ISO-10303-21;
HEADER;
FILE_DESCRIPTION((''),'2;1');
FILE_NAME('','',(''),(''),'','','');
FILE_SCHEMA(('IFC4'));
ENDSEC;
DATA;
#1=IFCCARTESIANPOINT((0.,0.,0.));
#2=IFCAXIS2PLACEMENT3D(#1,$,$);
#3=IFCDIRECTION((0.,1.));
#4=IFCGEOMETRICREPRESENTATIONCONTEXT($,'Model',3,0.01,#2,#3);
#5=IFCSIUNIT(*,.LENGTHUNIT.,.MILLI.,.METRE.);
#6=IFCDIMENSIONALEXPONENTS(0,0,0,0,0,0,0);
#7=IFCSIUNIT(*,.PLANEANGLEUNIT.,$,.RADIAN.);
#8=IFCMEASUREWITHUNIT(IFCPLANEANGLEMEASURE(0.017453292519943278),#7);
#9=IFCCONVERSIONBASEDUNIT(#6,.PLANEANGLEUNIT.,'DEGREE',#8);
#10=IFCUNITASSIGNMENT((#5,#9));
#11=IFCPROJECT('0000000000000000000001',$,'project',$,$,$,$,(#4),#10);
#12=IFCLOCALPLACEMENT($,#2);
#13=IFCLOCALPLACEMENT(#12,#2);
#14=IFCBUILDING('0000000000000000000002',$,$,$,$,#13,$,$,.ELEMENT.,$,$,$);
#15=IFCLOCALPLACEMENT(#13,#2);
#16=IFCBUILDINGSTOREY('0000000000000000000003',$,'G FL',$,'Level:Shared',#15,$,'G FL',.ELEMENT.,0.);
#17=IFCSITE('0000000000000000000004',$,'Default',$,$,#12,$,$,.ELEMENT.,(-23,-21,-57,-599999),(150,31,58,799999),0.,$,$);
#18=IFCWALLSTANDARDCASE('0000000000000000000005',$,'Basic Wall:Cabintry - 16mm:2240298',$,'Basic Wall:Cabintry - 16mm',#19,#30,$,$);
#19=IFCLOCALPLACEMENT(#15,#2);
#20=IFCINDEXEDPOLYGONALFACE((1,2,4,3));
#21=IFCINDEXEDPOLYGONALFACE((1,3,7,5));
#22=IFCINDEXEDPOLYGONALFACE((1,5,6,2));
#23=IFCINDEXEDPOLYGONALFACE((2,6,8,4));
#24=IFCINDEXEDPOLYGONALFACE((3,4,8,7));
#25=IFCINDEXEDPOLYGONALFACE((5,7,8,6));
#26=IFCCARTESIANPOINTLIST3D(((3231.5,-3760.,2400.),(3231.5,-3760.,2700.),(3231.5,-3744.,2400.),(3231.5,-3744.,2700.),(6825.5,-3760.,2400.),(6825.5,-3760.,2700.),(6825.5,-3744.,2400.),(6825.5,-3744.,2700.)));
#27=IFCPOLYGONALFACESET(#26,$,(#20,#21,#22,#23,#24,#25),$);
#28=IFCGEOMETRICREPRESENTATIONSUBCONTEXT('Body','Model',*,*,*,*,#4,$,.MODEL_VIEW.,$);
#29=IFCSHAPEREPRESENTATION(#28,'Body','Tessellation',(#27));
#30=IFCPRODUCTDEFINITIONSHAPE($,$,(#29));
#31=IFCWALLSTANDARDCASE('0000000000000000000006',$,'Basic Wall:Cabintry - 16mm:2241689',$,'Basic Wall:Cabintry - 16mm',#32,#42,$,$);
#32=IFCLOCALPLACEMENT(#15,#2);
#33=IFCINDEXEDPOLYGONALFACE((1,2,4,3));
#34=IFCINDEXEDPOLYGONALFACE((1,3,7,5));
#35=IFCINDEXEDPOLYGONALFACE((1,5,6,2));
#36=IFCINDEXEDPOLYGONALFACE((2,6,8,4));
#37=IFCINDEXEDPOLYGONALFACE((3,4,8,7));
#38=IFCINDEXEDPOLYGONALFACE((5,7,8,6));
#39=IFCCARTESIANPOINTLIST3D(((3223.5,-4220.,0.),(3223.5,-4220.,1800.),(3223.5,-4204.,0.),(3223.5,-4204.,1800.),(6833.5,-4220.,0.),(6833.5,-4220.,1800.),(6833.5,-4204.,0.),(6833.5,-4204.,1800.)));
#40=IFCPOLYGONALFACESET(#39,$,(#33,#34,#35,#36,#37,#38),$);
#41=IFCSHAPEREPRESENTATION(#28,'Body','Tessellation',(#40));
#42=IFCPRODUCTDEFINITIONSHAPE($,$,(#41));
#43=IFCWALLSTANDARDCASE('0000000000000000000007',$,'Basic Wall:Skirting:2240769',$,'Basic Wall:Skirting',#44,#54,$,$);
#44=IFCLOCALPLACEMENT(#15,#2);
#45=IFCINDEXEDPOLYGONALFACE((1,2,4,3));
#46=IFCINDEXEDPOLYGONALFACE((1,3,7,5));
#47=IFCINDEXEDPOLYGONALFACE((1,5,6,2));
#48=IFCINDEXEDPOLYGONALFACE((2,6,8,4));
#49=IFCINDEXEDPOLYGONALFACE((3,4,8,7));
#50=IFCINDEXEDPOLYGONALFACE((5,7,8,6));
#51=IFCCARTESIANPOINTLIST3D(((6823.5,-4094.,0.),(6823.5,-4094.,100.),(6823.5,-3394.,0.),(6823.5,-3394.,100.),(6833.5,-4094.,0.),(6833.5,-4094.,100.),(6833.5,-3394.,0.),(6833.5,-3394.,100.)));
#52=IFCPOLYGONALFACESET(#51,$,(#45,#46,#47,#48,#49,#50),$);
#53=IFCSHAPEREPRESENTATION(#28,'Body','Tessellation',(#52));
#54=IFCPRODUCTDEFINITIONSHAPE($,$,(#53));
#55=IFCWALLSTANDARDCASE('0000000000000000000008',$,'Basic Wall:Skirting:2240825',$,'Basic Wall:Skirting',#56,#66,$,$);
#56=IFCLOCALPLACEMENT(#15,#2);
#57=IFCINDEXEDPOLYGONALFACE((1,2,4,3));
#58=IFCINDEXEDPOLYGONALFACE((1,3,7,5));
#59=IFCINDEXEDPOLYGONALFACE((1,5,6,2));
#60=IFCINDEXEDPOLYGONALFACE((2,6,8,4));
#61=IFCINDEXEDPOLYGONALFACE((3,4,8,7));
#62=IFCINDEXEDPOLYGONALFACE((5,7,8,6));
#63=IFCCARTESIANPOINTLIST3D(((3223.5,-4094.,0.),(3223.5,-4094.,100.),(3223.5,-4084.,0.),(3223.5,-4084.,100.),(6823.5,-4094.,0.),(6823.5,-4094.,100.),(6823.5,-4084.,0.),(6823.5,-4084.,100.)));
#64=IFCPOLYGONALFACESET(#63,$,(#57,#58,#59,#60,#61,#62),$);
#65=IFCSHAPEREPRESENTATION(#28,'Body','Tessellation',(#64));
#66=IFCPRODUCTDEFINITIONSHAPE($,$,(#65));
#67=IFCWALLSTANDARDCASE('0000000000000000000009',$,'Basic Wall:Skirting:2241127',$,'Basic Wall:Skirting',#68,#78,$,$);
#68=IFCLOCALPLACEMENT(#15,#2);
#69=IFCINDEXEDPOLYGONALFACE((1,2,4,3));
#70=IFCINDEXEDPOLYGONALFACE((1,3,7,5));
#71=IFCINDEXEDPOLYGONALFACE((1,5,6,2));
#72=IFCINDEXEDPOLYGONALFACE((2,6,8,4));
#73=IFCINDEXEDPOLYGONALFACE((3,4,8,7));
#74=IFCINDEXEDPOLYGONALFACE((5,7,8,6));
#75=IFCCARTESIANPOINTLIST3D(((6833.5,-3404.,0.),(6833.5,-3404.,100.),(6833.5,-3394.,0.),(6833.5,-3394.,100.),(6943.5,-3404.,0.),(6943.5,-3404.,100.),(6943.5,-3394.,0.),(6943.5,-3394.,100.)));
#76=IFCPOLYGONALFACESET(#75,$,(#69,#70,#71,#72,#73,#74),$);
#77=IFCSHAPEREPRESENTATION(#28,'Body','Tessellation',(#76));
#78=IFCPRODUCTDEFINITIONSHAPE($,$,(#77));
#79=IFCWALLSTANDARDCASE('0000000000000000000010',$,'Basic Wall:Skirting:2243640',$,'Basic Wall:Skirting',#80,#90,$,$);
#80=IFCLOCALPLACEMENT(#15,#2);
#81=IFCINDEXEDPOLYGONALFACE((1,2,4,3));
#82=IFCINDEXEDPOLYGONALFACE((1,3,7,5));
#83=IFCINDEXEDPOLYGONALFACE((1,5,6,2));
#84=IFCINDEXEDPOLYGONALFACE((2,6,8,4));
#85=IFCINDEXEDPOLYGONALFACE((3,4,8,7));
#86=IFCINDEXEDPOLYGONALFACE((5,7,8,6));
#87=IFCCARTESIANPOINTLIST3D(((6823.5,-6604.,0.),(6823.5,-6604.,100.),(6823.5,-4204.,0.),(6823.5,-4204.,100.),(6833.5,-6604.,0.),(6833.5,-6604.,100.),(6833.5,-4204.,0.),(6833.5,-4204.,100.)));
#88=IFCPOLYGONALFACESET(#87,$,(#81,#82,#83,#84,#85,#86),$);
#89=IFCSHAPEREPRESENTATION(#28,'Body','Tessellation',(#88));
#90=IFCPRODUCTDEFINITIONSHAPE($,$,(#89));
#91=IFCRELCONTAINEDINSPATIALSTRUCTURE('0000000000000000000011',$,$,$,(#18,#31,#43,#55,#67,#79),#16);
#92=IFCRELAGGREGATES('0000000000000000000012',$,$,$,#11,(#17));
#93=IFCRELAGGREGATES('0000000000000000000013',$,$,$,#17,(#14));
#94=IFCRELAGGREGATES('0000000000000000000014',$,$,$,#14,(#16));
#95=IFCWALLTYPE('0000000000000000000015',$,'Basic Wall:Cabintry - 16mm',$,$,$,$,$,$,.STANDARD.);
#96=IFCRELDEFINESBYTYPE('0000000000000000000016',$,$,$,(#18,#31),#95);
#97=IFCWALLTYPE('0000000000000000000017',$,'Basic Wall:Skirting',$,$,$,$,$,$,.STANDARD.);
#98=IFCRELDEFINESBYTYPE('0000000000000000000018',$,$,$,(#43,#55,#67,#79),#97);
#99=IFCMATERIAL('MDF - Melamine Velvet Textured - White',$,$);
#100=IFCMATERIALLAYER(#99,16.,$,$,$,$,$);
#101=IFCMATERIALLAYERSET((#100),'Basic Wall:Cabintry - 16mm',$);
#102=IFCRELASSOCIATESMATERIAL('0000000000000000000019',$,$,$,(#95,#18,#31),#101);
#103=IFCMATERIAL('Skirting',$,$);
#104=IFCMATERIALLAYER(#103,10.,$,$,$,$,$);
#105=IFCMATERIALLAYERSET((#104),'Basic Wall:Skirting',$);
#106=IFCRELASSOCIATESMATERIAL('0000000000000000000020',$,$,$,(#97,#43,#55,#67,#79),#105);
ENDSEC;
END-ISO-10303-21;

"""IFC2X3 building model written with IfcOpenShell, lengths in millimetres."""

from ifc_helpers import new_model, entity, si_unit, converted_unit, direction, frame, frame_2d, origin, place, context, subcontext, project, spatial, rectangle, extrude, material, layer, layer_set, layer_usage, type_object, element, save


model = new_model("IFC2X3")

# Units and contexts
model_context = context("Model", 3, precision=0.01, world=origin(), true_north=direction((0.0, 1.0)))
body_context = subcontext(model_context, "Body", "Model", "MODEL_VIEW")
ifc_project = project(units=[si_unit("LENGTHUNIT", "METRE", prefix="MILLI"), converted_unit("PLANEANGLEUNIT", "DEGREE", entity("IfcPlaneAngleMeasure", 0.017453292519943278), si_unit("PLANEANGLEUNIT", "RADIAN"), dimensions=[0, 0, 0, 0, 0, 0, 0])], contexts=[model_context])

# Site, building, storey
site_placement = place(None, origin())
site = spatial("IfcSite", under=ifc_project, at=site_placement, Name="Default", CompositionType="ELEMENT", RefLatitude=(-23, -21, -57, -599999), RefLongitude=(150, 31, 58, 799999), RefElevation=0.0)
building_placement = place(site_placement, origin())
building = spatial("IfcBuilding", under=site, at=building_placement, CompositionType="ELEMENT")
storey_placement = place(building_placement, origin())
storey = spatial("IfcBuildingStorey", under=building, at=storey_placement, Name="G FL", ObjectType="Level:Shared", LongName="G FL", CompositionType="ELEMENT", Elevation=0.0)

# Walls
ifc_material_1 = material(Name="MDF - Melamine Velvet Textured - White")
ifc_layer_1 = layer(ifc_material_1, 16.0)
ifc_layer_set_1 = layer_set([ifc_layer_1], Name="Basic Wall:Cabintry - 16mm")
wall_type_1 = type_object("IfcWallType", Name="Basic Wall:Cabintry - 16mm", PredefinedType="STANDARD", material=ifc_layer_set_1)
ifc_layer_usage_1 = layer_usage(ifc_layer_set_1, "AXIS2", "NEGATIVE", 8.0)
wall_1_placement = place(storey_placement, frame((6825.5, -3752.0, 2400.0), z_axis=(0.0, 0.0, 1.0), x_axis=(-1.0, 0.0, 0.0)))
element("IfcWallStandardCase", 1, at=wall_1_placement, inside=storey, type_object=wall_type_1, material=ifc_layer_usage_1, Name="Basic Wall:Cabintry - 16mm:2240298", ObjectType="Basic Wall:Cabintry - 16mm", context=body_context, shape_type="SweptSolid", body=[
    extrude(rectangle(XDim=3594.0, YDim=16.0, at=frame_2d((1797.0, 0.0), x_axis=(-1.0, 0.0))), origin(), (0.0, 0.0, 1.0), 300.0),
])
ifc_layer_usage_2 = layer_usage(ifc_layer_set_1, "AXIS2", "NEGATIVE", 8.0)
wall_2_placement = place(storey_placement, frame((6833.5, -4212.0, 0.0), z_axis=(0.0, 0.0, 1.0), x_axis=(-1.0, 0.0, 0.0)))
element("IfcWallStandardCase", 2, at=wall_2_placement, inside=storey, type_object=wall_type_1, material=ifc_layer_usage_2, Name="Basic Wall:Cabintry - 16mm:2241689", ObjectType="Basic Wall:Cabintry - 16mm", context=body_context, shape_type="SweptSolid", body=[
    extrude(rectangle(XDim=3610.0, YDim=16.0, at=frame_2d((1805.0, 0.0), x_axis=(-1.0, 0.0))), origin(), (0.0, 0.0, 1.0), 1800.0),
])

# Shared definitions
ifc_material_2 = material(Name="Skirting")
ifc_layer_2 = layer(ifc_material_2, 10.0)
ifc_layer_set_2 = layer_set([ifc_layer_2], Name="Basic Wall:Skirting")
wall_type_2 = type_object("IfcWallType", Name="Basic Wall:Skirting", PredefinedType="STANDARD", material=ifc_layer_set_2)

# Walls
ifc_layer_usage_3 = layer_usage(ifc_layer_set_2, "AXIS2", "NEGATIVE", 5.0)
wall_3_placement = place(storey_placement, frame((6828.5, -3394.0, 0.0), z_axis=(0.0, 0.0, 1.0), x_axis=(0.0, -1.0, 0.0)))
element("IfcWallStandardCase", 3, at=wall_3_placement, inside=storey, type_object=wall_type_2, material=ifc_layer_usage_3, Name="Basic Wall:Skirting:2240769", ObjectType="Basic Wall:Skirting", context=body_context, shape_type="SweptSolid", body=[
    extrude(rectangle(XDim=700.0, YDim=10.0, at=frame_2d((350.0, 0.0), x_axis=(-1.0, 0.0))), origin(), (0.0, 0.0, 1.0), 100.0),
])
ifc_layer_usage_4 = layer_usage(ifc_layer_set_2, "AXIS2", "NEGATIVE", 5.0)
wall_4_placement = place(storey_placement, frame((6823.5, -4089.0, 0.0), z_axis=(0.0, 0.0, 1.0), x_axis=(-1.0, 0.0, 0.0)))
element("IfcWallStandardCase", 4, at=wall_4_placement, inside=storey, type_object=wall_type_2, material=ifc_layer_usage_4, Name="Basic Wall:Skirting:2240825", ObjectType="Basic Wall:Skirting", context=body_context, shape_type="SweptSolid", body=[
    extrude(rectangle(XDim=3600.0, YDim=10.0, at=frame_2d((1800.0, 0.0), x_axis=(-1.0, 0.0))), origin(), (0.0, 0.0, 1.0), 100.0),
])
ifc_layer_usage_5 = layer_usage(ifc_layer_set_2, "AXIS2", "NEGATIVE", 5.0)
wall_5_placement = place(storey_placement, frame((6943.5, -3399.0, 0.0), z_axis=(0.0, 0.0, 1.0), x_axis=(-1.0, 0.0, 0.0)))
element("IfcWallStandardCase", 5, at=wall_5_placement, inside=storey, type_object=wall_type_2, material=ifc_layer_usage_5, Name="Basic Wall:Skirting:2241127", ObjectType="Basic Wall:Skirting", context=body_context, shape_type="SweptSolid", body=[
    extrude(rectangle(XDim=110.0, YDim=10.0, at=frame_2d((55.0, 0.0), x_axis=(-1.0, 0.0))), origin(), (0.0, 0.0, 1.0), 100.0),
])
ifc_layer_usage_6 = layer_usage(ifc_layer_set_2, "AXIS2", "NEGATIVE", 5.0)
wall_6_placement = place(storey_placement, frame((6828.5, -4204.0, 0.0), z_axis=(0.0, 0.0, 1.0), x_axis=(0.0, -1.0, 0.0)))
element("IfcWallStandardCase", 6, at=wall_6_placement, inside=storey, type_object=wall_type_2, material=ifc_layer_usage_6, Name="Basic Wall:Skirting:2243640", ObjectType="Basic Wall:Skirting", context=body_context, shape_type="SweptSolid", body=[
    extrude(rectangle(XDim=2400.0, YDim=10.0, at=frame_2d((1200.0, 0.0), x_axis=(-1.0, 0.0))), origin(), (0.0, 0.0, 1.0), 100.0),
])

save(model, "model.ifc")
